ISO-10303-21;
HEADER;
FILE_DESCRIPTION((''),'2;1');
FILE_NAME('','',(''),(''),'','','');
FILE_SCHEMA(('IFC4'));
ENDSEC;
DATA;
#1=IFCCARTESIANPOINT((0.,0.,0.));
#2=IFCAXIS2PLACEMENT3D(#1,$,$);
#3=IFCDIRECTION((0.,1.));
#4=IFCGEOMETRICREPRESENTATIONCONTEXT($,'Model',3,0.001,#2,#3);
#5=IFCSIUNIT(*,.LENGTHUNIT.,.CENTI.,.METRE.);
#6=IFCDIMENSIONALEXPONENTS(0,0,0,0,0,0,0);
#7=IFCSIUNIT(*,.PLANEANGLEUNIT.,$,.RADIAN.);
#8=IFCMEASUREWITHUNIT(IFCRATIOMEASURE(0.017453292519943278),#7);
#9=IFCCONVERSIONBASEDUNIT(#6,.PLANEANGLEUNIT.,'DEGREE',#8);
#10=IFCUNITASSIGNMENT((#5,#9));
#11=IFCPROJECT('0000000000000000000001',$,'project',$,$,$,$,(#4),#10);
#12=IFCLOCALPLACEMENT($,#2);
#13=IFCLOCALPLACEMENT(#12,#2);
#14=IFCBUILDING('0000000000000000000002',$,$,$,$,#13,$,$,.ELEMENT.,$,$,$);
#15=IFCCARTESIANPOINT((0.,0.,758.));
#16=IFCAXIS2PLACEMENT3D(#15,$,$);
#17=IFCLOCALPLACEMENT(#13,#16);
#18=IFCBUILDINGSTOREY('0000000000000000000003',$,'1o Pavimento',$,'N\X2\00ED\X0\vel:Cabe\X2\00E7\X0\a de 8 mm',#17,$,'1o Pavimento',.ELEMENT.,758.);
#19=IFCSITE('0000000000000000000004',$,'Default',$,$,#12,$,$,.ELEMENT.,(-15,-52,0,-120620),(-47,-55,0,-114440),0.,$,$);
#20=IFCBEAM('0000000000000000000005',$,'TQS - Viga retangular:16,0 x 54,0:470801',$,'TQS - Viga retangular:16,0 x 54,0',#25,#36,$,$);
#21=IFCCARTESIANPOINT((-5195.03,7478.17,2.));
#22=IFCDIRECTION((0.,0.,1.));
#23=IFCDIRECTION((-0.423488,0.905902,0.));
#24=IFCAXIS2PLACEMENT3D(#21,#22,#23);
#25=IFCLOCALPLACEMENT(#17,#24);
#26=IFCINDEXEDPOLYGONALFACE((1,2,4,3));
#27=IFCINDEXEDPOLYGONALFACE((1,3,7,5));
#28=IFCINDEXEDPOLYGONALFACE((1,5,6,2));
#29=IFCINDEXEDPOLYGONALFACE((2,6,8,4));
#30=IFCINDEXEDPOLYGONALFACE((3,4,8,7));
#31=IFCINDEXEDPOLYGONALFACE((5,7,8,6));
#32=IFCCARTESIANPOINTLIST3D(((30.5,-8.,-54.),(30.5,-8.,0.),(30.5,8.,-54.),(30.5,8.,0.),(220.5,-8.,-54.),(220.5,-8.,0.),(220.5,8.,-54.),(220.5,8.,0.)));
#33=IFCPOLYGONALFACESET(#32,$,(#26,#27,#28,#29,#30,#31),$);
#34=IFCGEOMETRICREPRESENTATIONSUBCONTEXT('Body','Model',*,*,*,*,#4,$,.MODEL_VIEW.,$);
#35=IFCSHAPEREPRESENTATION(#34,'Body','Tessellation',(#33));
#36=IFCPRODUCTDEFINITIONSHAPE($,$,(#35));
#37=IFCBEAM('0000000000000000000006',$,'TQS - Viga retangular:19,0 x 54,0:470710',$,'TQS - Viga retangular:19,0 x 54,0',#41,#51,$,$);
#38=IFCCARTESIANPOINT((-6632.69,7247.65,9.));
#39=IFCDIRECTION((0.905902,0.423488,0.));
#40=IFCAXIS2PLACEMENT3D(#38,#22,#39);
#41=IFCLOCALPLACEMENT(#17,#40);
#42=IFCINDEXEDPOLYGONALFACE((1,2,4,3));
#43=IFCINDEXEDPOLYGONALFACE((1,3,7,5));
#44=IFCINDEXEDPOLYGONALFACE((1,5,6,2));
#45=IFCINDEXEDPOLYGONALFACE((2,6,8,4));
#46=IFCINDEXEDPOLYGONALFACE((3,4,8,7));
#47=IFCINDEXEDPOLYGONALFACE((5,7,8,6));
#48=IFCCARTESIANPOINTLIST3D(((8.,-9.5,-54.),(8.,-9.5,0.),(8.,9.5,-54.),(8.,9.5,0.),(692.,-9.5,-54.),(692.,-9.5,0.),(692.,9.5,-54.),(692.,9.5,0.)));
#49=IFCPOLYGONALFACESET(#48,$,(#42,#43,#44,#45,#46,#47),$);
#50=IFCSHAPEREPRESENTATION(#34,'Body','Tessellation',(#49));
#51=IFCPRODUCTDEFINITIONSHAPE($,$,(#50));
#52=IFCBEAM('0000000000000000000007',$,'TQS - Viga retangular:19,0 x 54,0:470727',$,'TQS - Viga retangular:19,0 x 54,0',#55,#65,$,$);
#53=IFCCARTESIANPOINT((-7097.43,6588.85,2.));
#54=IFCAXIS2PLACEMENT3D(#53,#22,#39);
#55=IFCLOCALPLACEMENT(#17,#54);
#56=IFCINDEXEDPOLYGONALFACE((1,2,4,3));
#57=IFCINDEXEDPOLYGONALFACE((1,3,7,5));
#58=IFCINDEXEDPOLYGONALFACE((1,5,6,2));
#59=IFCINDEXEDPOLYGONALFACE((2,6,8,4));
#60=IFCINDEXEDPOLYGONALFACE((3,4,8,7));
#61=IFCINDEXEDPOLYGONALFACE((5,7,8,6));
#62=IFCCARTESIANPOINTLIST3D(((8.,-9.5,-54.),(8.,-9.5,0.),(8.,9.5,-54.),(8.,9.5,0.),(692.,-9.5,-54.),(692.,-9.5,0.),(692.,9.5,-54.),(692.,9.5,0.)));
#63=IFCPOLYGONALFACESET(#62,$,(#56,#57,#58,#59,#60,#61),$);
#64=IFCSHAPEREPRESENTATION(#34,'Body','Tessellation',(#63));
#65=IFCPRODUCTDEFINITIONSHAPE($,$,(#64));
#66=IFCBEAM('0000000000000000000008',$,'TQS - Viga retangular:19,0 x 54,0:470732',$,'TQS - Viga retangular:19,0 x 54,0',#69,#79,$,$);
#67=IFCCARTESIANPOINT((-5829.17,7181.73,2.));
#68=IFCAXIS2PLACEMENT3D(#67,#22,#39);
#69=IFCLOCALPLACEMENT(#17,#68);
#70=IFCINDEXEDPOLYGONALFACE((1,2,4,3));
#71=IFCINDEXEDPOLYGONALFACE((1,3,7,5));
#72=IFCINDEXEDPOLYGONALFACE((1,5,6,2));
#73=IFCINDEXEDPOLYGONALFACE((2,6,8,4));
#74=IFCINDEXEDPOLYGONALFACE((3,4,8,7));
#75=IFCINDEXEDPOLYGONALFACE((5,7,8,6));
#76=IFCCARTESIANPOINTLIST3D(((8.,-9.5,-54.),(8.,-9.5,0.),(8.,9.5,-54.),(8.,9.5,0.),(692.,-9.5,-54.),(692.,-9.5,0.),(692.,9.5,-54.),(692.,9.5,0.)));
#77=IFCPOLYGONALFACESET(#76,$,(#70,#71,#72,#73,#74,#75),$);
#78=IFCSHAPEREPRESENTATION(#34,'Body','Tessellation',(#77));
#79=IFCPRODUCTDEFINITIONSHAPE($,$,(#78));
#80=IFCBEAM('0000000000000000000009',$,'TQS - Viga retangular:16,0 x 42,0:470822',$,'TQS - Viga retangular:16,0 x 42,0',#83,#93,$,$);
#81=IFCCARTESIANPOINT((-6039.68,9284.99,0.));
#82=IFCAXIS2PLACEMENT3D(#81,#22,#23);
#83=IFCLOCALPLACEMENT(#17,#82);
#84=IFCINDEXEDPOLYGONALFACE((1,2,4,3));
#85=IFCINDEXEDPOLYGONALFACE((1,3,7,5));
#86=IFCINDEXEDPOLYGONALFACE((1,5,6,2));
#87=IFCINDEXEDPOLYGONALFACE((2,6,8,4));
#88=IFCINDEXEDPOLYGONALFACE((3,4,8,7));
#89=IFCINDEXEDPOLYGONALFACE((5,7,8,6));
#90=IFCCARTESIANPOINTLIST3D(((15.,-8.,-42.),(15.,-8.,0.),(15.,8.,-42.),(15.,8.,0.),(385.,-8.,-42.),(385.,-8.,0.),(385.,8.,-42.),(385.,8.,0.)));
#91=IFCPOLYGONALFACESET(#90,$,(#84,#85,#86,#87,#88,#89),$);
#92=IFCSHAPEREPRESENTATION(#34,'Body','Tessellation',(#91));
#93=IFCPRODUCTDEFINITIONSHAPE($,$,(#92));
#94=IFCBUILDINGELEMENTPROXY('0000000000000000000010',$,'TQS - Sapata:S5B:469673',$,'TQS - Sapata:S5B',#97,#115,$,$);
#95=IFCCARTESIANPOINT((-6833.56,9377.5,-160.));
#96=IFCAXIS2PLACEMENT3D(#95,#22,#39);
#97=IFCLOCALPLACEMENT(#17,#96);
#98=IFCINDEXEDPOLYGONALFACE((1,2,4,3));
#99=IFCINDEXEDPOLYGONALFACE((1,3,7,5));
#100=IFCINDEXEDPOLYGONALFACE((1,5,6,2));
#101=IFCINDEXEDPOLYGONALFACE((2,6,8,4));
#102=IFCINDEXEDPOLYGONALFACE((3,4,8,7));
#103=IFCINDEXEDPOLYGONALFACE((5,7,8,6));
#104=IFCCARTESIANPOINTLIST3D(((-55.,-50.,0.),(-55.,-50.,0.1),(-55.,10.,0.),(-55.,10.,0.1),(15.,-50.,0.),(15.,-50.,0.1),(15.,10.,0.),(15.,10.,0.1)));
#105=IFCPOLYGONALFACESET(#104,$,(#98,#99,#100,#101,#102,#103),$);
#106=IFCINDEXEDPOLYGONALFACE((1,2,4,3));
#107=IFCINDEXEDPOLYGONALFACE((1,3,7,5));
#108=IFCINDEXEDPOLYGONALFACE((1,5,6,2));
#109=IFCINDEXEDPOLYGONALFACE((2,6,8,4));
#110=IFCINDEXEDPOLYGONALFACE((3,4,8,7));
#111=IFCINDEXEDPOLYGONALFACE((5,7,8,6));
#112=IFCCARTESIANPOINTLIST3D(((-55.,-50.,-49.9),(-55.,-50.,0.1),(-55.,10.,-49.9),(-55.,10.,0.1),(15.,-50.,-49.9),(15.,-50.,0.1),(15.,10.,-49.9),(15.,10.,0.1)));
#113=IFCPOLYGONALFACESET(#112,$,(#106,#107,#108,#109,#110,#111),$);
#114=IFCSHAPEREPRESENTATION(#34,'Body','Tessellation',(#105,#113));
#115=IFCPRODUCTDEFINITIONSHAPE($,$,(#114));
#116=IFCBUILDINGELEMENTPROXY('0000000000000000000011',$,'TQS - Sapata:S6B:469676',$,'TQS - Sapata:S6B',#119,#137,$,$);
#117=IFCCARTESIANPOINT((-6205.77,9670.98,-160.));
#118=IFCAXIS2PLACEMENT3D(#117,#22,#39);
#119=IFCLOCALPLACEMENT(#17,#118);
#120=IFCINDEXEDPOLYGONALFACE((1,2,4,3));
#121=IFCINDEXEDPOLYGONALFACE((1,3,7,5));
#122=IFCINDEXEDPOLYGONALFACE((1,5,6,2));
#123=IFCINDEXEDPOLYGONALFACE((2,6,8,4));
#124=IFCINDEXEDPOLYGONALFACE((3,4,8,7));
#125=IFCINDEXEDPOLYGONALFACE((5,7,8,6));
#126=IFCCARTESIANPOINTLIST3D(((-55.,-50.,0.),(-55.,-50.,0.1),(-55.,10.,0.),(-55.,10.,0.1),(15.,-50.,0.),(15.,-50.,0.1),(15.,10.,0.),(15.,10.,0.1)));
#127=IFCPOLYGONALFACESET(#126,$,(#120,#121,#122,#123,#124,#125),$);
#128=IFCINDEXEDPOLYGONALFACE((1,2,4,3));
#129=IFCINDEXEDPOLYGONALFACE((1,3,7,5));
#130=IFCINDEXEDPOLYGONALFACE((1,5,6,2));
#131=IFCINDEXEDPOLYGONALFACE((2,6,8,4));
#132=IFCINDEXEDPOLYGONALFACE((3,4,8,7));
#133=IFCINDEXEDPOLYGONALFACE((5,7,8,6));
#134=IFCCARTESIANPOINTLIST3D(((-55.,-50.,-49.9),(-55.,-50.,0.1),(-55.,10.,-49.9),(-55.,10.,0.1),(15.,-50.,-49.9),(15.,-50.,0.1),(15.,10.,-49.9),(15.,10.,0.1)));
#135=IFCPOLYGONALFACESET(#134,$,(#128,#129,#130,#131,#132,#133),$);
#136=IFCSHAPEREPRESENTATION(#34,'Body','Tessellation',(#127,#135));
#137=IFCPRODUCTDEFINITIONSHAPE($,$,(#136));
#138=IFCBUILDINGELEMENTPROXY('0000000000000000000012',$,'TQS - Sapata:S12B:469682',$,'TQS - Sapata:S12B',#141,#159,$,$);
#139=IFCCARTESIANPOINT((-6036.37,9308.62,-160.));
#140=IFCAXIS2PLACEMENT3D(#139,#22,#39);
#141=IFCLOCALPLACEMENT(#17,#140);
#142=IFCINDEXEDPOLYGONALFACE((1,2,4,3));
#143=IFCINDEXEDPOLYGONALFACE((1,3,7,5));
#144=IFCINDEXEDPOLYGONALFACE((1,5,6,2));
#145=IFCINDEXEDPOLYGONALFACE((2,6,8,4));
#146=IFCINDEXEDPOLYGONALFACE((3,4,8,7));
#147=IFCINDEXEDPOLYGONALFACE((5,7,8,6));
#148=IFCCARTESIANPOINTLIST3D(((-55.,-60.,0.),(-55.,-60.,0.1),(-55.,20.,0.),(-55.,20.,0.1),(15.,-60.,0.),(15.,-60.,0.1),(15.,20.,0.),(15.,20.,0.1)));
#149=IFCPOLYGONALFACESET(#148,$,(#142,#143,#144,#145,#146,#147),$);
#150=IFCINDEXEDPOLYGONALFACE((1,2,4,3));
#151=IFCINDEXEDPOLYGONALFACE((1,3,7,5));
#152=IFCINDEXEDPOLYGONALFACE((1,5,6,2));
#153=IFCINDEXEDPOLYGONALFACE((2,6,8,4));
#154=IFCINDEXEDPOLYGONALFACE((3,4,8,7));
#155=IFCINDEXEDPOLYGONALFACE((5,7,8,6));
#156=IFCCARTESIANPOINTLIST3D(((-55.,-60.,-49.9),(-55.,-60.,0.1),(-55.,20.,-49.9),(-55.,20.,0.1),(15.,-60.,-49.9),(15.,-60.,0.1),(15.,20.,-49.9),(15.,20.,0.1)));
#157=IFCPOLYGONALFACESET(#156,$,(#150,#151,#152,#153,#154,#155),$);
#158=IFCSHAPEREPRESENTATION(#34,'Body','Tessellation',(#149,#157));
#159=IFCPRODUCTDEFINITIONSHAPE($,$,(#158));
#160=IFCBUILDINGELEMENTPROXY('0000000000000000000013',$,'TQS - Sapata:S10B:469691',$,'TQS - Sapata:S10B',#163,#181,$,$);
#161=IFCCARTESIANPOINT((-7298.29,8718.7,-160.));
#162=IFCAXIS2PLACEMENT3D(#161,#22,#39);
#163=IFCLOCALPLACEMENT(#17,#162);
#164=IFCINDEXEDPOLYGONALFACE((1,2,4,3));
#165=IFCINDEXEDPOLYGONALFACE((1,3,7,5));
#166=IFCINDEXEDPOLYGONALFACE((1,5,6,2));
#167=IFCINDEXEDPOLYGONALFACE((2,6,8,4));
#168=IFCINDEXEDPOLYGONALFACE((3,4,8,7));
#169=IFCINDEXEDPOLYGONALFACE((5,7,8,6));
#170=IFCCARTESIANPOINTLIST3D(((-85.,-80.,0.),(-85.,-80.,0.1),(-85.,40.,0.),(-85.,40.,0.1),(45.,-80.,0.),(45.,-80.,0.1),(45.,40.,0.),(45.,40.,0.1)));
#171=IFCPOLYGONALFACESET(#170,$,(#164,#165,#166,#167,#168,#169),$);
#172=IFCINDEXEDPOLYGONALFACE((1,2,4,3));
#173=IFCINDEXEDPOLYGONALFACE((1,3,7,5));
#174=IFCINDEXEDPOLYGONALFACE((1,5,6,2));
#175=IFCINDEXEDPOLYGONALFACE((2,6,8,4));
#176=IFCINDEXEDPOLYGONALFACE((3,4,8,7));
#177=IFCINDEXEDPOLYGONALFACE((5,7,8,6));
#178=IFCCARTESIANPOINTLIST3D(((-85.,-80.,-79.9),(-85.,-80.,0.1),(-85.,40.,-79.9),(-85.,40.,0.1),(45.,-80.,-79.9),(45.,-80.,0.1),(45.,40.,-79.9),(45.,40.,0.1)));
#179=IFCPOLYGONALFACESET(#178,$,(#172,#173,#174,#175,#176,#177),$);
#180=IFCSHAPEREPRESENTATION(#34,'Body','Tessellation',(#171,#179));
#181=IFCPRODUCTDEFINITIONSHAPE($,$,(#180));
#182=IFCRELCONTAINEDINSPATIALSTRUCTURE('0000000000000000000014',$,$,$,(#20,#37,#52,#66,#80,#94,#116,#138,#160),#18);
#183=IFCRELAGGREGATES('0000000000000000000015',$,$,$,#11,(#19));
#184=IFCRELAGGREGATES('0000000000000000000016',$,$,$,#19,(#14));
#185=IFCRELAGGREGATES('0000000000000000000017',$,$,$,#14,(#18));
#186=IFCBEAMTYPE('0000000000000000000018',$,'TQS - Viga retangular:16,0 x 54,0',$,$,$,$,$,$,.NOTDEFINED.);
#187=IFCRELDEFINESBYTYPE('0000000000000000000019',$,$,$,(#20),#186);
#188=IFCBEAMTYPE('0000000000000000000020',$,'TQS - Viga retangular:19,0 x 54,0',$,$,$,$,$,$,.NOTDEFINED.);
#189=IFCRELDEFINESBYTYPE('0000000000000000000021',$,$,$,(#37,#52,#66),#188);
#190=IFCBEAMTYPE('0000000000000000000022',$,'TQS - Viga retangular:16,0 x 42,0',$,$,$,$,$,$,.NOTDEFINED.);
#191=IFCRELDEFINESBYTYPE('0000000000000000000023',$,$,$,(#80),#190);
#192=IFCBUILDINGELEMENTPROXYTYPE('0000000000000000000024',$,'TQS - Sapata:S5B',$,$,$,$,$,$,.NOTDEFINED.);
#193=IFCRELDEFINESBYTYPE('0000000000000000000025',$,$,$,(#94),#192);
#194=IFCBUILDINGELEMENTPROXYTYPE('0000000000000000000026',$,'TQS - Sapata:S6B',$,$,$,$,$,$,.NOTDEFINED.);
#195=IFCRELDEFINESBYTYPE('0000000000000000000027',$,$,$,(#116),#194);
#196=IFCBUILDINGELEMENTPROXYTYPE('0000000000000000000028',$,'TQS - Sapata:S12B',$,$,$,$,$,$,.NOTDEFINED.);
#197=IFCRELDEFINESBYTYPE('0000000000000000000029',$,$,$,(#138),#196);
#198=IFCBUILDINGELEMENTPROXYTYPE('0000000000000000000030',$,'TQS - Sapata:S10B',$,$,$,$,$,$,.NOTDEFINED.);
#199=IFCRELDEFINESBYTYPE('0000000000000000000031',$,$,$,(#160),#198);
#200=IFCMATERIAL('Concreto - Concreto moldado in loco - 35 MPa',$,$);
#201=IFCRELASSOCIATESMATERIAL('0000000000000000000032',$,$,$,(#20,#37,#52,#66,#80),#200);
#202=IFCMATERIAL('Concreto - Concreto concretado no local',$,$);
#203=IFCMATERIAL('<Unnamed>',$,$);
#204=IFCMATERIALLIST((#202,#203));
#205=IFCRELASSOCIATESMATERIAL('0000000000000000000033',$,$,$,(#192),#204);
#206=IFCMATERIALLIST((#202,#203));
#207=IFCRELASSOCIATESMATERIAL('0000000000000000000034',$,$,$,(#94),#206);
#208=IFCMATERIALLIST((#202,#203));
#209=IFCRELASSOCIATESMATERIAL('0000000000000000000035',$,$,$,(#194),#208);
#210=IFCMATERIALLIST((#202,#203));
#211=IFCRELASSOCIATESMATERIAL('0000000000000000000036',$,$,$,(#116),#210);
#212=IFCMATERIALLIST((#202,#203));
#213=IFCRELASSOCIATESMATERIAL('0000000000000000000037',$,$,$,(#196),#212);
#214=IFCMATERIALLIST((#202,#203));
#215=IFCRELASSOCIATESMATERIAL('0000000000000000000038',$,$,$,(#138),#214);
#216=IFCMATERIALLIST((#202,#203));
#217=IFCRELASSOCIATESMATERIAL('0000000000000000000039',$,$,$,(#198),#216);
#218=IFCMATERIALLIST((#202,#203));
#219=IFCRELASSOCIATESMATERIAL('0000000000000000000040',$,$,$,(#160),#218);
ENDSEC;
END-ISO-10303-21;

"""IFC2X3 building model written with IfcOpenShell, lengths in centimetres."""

from ifc_helpers import new_model, entity, si_unit, converted_unit, direction, frame, frame_2d, origin, origin_2d_with_axis, place, context, subcontext, project, spatial, rectangle, extrude, source, transform, mapped, material, material_list, type_object, type_shapes, element, save


model = new_model("IFC2X3")

# Units and contexts
model_context = context("Model", 3, precision=0.001, world=origin(), true_north=direction((0.0, 1.0)))
body_context = subcontext(model_context, "Body", "Model", "MODEL_VIEW")
ifc_project = project(units=[si_unit("LENGTHUNIT", "METRE", prefix="CENTI"), converted_unit("PLANEANGLEUNIT", "DEGREE", entity("IfcRatioMeasure", 0.017453292519943278), si_unit("PLANEANGLEUNIT", "RADIAN"), dimensions=[0, 0, 0, 0, 0, 0, 0])], contexts=[model_context])

# Site, building, storey
site_placement = place(None, origin())
site = spatial("IfcSite", under=ifc_project, at=site_placement, Name="Default", CompositionType="ELEMENT", RefLatitude=(-15, -52, 0, -120620), RefLongitude=(-47, -55, 0, -114440), RefElevation=0.0)
building_placement = place(site_placement, origin())
building = spatial("IfcBuilding", under=site, at=building_placement, CompositionType="ELEMENT")
storey_placement = place(building_placement, frame((0.0, 0.0, 758.0)))
storey = spatial("IfcBuildingStorey", under=building, at=storey_placement, Name="1o Pavimento", ObjectType="Nível:Cabeça de 8 mm", LongName="1o Pavimento", CompositionType="ELEMENT", Elevation=758.0)

# Beams
ifc_material_1 = material(Name="Concreto - Concreto moldado in loco - 35 MPa")
beam_type_1 = type_object("IfcBeamType", Name="TQS - Viga retangular:16,0 x 54,0", PredefinedType="NOTDEFINED")
beam_1_placement = place(storey_placement, frame((-5195.03, 7478.17, 2.0), z_axis=(0.0, 0.0, 1.0), x_axis=(-0.423488, 0.905902, 0.0)))
element("IfcBeam", 1, at=beam_1_placement, inside=storey, type_object=beam_type_1, material=ifc_material_1, Name="TQS - Viga retangular:16,0 x 54,0:470801", ObjectType="TQS - Viga retangular:16,0 x 54,0", context=body_context, shape_type="SweptSolid", body=[
    extrude(rectangle(XDim=54.0, YDim=16.0, at=frame_2d((0.0, 0.0), x_axis=(1.0, 0.0))), frame((30.5, 0.0, -27.0), z_axis=(1.0, 0.0, 0.0), x_axis=(0.0, 0.0, -1.0)), (0.0, 0.0, 1.0), 190.0),
])
beam_type_2 = type_object("IfcBeamType", Name="TQS - Viga retangular:19,0 x 54,0", PredefinedType="NOTDEFINED")
beam_2_placement = place(storey_placement, frame((-6632.69, 7247.65, 9.0), z_axis=(0.0, 0.0, 1.0), x_axis=(0.905902, 0.423488, 0.0)))
element("IfcBeam", 2, at=beam_2_placement, inside=storey, type_object=beam_type_2, material=ifc_material_1, Name="TQS - Viga retangular:19,0 x 54,0:470710", ObjectType="TQS - Viga retangular:19,0 x 54,0", context=body_context, shape_type="SweptSolid", body=[
    extrude(rectangle(XDim=54.0, YDim=19.0, at=frame_2d((0.0, 0.0), x_axis=(1.0, 0.0))), frame((8.0, 0.0, -27.0), z_axis=(1.0, 0.0, 0.0), x_axis=(0.0, 0.0, -1.0)), (0.0, 0.0, 1.0), 684.0),
])
beam_3_placement = place(storey_placement, frame((-7097.43, 6588.85, 2.0), z_axis=(0.0, 0.0, 1.0), x_axis=(0.905902, 0.423488, 0.0)))
element("IfcBeam", 3, at=beam_3_placement, inside=storey, type_object=beam_type_2, material=ifc_material_1, Name="TQS - Viga retangular:19,0 x 54,0:470727", ObjectType="TQS - Viga retangular:19,0 x 54,0", context=body_context, shape_type="SweptSolid", body=[
    extrude(rectangle(XDim=54.0, YDim=19.0, at=frame_2d((0.0, 0.0), x_axis=(1.0, 0.0))), frame((8.0, 0.0, -27.0), z_axis=(1.0, 0.0, 0.0), x_axis=(0.0, 0.0, -1.0)), (0.0, 0.0, 1.0), 684.0),
])
beam_4_placement = place(storey_placement, frame((-5829.17, 7181.73, 2.0), z_axis=(0.0, 0.0, 1.0), x_axis=(0.905902, 0.423488, 0.0)))
element("IfcBeam", 4, at=beam_4_placement, inside=storey, type_object=beam_type_2, material=ifc_material_1, Name="TQS - Viga retangular:19,0 x 54,0:470732", ObjectType="TQS - Viga retangular:19,0 x 54,0", context=body_context, shape_type="SweptSolid", body=[
    extrude(rectangle(XDim=54.0, YDim=19.0, at=frame_2d((0.0, 0.0), x_axis=(1.0, 0.0))), frame((8.0, 0.0, -27.0), z_axis=(1.0, 0.0, 0.0), x_axis=(0.0, 0.0, -1.0)), (0.0, 0.0, 1.0), 684.0),
])
beam_type_3 = type_object("IfcBeamType", Name="TQS - Viga retangular:16,0 x 42,0", PredefinedType="NOTDEFINED")
beam_5_placement = place(storey_placement, frame((-6039.68, 9284.99, 0.0), z_axis=(0.0, 0.0, 1.0), x_axis=(-0.423488, 0.905902, 0.0)))
element("IfcBeam", 5, at=beam_5_placement, inside=storey, type_object=beam_type_3, material=ifc_material_1, Name="TQS - Viga retangular:16,0 x 42,0:470822", ObjectType="TQS - Viga retangular:16,0 x 42,0", context=body_context, shape_type="SweptSolid", body=[
    extrude(rectangle(XDim=42.0, YDim=16.0, at=frame_2d((0.0, 0.0), x_axis=(1.0, 0.0))), frame((15.0, 0.0, -21.0), z_axis=(1.0, 0.0, 0.0), x_axis=(0.0, 0.0, -1.0)), (0.0, 0.0, 1.0), 370.0),
])

# Building element proxies
ifc_material_2 = material(Name="Concreto - Concreto concretado no local")
ifc_material_3 = material(Name="<Unnamed>")
ifc_material_list_1 = material_list([ifc_material_2, ifc_material_3])
ifc_material_list_2 = material_list([ifc_material_2, ifc_material_3])
building_element_proxy_type_1 = type_object("IfcBuildingElementProxyType", Name="TQS - Sapata:S5B", PredefinedType="NOTDEFINED", material=ifc_material_list_2)
shared_shape_1 = source(origin(), body_context, "Body", "SweptSolid", [
    extrude(rectangle(XDim=70.0, YDim=60.0, at=frame_2d((0.0, 0.0), x_axis=(1.0, 0.0))), frame((-20.0, -20.0, 0.0), z_axis=(0.0, 0.0, 1.0), x_axis=(-1.0, 0.0, 0.0)), (0.0, 0.0, 1.0), 0.1),
    extrude(rectangle(XDim=70.0, YDim=60.0, at=frame_2d((0.0, 0.0), x_axis=(1.0, 0.0))), frame((-20.0, -20.0, -49.9), z_axis=(0.0, 0.0, 1.0), x_axis=(-1.0, 0.0, 0.0)), (0.0, 0.0, 1.0), 50.0),
])
type_shapes(building_element_proxy_type_1, [shared_shape_1])
proxy_1_placement = place(storey_placement, frame((-6833.56, 9377.5, -160.0), z_axis=(0.0, 0.0, 1.0), x_axis=(0.905902, 0.423488, 0.0)))
element("IfcBuildingElementProxy", 6, at=proxy_1_placement, inside=storey, type_object=building_element_proxy_type_1, material=ifc_material_list_1, Name="TQS - Sapata:S5B:469673", ObjectType="TQS - Sapata:S5B", context=body_context, shape_type="MappedRepresentation", body=[
    mapped(shared_shape_1, transform((0.0, 0.0, 0.0), scale=1.0)),
])
ifc_material_list_3 = material_list([ifc_material_2, ifc_material_3])
ifc_material_list_4 = material_list([ifc_material_2, ifc_material_3])
building_element_proxy_type_2 = type_object("IfcBuildingElementProxyType", Name="TQS - Sapata:S6B", PredefinedType="NOTDEFINED", material=ifc_material_list_4)
shared_shape_2 = source(origin(), body_context, "Body", "SweptSolid", [
    extrude(rectangle(XDim=70.0, YDim=60.0, at=frame_2d((0.0, 0.0), x_axis=(1.0, 0.0))), frame((-20.0, -20.0, 0.0), z_axis=(0.0, 0.0, 1.0), x_axis=(-1.0, 0.0, 0.0)), (0.0, 0.0, 1.0), 0.1),
    extrude(rectangle(XDim=70.0, YDim=60.0, at=frame_2d((0.0, 0.0), x_axis=(1.0, 0.0))), frame((-20.0, -20.0, -49.9), z_axis=(0.0, 0.0, 1.0), x_axis=(-1.0, 0.0, 0.0)), (0.0, 0.0, 1.0), 50.0),
])
type_shapes(building_element_proxy_type_2, [shared_shape_2])
proxy_2_placement = place(storey_placement, frame((-6205.77, 9670.98, -160.0), z_axis=(0.0, 0.0, 1.0), x_axis=(0.905902, 0.423488, 0.0)))
element("IfcBuildingElementProxy", 7, at=proxy_2_placement, inside=storey, type_object=building_element_proxy_type_2, material=ifc_material_list_3, Name="TQS - Sapata:S6B:469676", ObjectType="TQS - Sapata:S6B", context=body_context, shape_type="MappedRepresentation", body=[
    mapped(shared_shape_2, transform((0.0, 0.0, 0.0), scale=1.0)),
])
ifc_material_list_5 = material_list([ifc_material_2, ifc_material_3])
ifc_material_list_6 = material_list([ifc_material_2, ifc_material_3])
building_element_proxy_type_3 = type_object("IfcBuildingElementProxyType", Name="TQS - Sapata:S12B", PredefinedType="NOTDEFINED", material=ifc_material_list_6)
shared_shape_3 = source(origin(), body_context, "Body", "SweptSolid", [
    extrude(rectangle(XDim=70.0, YDim=80.0, at=frame_2d((0.0, 0.0), x_axis=(1.0, 0.0))), frame((-20.0, -20.0, 0.0), z_axis=(0.0, 0.0, 1.0), x_axis=(-1.0, 0.0, 0.0)), (0.0, 0.0, 1.0), 0.1),
    extrude(rectangle(XDim=70.0, YDim=80.0, at=frame_2d((0.0, 0.0), x_axis=(1.0, 0.0))), frame((-20.0, -20.0, -49.9), z_axis=(0.0, 0.0, 1.0), x_axis=(-1.0, 0.0, 0.0)), (0.0, 0.0, 1.0), 50.0),
])
type_shapes(building_element_proxy_type_3, [shared_shape_3])
proxy_3_placement = place(storey_placement, frame((-6036.37, 9308.62, -160.0), z_axis=(0.0, 0.0, 1.0), x_axis=(0.905902, 0.423488, 0.0)))
element("IfcBuildingElementProxy", 8, at=proxy_3_placement, inside=storey, type_object=building_element_proxy_type_3, material=ifc_material_list_5, Name="TQS - Sapata:S12B:469682", ObjectType="TQS - Sapata:S12B", context=body_context, shape_type="MappedRepresentation", body=[
    mapped(shared_shape_3, transform((0.0, 0.0, 0.0), scale=1.0)),
])
ifc_material_list_7 = material_list([ifc_material_2, ifc_material_3])
ifc_material_list_8 = material_list([ifc_material_2, ifc_material_3])
building_element_proxy_type_4 = type_object("IfcBuildingElementProxyType", Name="TQS - Sapata:S10B", PredefinedType="NOTDEFINED", material=ifc_material_list_8)
shared_shape_4 = source(origin(), body_context, "Body", "SweptSolid", [
    extrude(rectangle(XDim=130.0, YDim=120.0, at=frame_2d((0.0, 0.0), x_axis=(1.0, 0.0))), frame((-20.0, -20.0, 0.0), z_axis=(0.0, 0.0, 1.0), x_axis=(-1.0, 0.0, 0.0)), (0.0, 0.0, 1.0), 0.1),
    extrude(rectangle(XDim=130.0, YDim=120.0, at=origin_2d_with_axis()), frame((-20.0, -20.0, -79.9), z_axis=(0.0, 0.0, 1.0), x_axis=(-1.0, 0.0, 0.0)), (0.0, 0.0, 1.0), 80.0),
])
type_shapes(building_element_proxy_type_4, [shared_shape_4])
proxy_4_placement = place(storey_placement, frame((-7298.29, 8718.7, -160.0), z_axis=(0.0, 0.0, 1.0), x_axis=(0.905902, 0.423488, 0.0)))
element("IfcBuildingElementProxy", 9, at=proxy_4_placement, inside=storey, type_object=building_element_proxy_type_4, material=ifc_material_list_7, Name="TQS - Sapata:S10B:469691", ObjectType="TQS - Sapata:S10B", context=body_context, shape_type="MappedRepresentation", body=[
    mapped(shared_shape_4, transform((0.0, 0.0, 0.0), scale=1.0)),
])

save(model, "model.ifc")
